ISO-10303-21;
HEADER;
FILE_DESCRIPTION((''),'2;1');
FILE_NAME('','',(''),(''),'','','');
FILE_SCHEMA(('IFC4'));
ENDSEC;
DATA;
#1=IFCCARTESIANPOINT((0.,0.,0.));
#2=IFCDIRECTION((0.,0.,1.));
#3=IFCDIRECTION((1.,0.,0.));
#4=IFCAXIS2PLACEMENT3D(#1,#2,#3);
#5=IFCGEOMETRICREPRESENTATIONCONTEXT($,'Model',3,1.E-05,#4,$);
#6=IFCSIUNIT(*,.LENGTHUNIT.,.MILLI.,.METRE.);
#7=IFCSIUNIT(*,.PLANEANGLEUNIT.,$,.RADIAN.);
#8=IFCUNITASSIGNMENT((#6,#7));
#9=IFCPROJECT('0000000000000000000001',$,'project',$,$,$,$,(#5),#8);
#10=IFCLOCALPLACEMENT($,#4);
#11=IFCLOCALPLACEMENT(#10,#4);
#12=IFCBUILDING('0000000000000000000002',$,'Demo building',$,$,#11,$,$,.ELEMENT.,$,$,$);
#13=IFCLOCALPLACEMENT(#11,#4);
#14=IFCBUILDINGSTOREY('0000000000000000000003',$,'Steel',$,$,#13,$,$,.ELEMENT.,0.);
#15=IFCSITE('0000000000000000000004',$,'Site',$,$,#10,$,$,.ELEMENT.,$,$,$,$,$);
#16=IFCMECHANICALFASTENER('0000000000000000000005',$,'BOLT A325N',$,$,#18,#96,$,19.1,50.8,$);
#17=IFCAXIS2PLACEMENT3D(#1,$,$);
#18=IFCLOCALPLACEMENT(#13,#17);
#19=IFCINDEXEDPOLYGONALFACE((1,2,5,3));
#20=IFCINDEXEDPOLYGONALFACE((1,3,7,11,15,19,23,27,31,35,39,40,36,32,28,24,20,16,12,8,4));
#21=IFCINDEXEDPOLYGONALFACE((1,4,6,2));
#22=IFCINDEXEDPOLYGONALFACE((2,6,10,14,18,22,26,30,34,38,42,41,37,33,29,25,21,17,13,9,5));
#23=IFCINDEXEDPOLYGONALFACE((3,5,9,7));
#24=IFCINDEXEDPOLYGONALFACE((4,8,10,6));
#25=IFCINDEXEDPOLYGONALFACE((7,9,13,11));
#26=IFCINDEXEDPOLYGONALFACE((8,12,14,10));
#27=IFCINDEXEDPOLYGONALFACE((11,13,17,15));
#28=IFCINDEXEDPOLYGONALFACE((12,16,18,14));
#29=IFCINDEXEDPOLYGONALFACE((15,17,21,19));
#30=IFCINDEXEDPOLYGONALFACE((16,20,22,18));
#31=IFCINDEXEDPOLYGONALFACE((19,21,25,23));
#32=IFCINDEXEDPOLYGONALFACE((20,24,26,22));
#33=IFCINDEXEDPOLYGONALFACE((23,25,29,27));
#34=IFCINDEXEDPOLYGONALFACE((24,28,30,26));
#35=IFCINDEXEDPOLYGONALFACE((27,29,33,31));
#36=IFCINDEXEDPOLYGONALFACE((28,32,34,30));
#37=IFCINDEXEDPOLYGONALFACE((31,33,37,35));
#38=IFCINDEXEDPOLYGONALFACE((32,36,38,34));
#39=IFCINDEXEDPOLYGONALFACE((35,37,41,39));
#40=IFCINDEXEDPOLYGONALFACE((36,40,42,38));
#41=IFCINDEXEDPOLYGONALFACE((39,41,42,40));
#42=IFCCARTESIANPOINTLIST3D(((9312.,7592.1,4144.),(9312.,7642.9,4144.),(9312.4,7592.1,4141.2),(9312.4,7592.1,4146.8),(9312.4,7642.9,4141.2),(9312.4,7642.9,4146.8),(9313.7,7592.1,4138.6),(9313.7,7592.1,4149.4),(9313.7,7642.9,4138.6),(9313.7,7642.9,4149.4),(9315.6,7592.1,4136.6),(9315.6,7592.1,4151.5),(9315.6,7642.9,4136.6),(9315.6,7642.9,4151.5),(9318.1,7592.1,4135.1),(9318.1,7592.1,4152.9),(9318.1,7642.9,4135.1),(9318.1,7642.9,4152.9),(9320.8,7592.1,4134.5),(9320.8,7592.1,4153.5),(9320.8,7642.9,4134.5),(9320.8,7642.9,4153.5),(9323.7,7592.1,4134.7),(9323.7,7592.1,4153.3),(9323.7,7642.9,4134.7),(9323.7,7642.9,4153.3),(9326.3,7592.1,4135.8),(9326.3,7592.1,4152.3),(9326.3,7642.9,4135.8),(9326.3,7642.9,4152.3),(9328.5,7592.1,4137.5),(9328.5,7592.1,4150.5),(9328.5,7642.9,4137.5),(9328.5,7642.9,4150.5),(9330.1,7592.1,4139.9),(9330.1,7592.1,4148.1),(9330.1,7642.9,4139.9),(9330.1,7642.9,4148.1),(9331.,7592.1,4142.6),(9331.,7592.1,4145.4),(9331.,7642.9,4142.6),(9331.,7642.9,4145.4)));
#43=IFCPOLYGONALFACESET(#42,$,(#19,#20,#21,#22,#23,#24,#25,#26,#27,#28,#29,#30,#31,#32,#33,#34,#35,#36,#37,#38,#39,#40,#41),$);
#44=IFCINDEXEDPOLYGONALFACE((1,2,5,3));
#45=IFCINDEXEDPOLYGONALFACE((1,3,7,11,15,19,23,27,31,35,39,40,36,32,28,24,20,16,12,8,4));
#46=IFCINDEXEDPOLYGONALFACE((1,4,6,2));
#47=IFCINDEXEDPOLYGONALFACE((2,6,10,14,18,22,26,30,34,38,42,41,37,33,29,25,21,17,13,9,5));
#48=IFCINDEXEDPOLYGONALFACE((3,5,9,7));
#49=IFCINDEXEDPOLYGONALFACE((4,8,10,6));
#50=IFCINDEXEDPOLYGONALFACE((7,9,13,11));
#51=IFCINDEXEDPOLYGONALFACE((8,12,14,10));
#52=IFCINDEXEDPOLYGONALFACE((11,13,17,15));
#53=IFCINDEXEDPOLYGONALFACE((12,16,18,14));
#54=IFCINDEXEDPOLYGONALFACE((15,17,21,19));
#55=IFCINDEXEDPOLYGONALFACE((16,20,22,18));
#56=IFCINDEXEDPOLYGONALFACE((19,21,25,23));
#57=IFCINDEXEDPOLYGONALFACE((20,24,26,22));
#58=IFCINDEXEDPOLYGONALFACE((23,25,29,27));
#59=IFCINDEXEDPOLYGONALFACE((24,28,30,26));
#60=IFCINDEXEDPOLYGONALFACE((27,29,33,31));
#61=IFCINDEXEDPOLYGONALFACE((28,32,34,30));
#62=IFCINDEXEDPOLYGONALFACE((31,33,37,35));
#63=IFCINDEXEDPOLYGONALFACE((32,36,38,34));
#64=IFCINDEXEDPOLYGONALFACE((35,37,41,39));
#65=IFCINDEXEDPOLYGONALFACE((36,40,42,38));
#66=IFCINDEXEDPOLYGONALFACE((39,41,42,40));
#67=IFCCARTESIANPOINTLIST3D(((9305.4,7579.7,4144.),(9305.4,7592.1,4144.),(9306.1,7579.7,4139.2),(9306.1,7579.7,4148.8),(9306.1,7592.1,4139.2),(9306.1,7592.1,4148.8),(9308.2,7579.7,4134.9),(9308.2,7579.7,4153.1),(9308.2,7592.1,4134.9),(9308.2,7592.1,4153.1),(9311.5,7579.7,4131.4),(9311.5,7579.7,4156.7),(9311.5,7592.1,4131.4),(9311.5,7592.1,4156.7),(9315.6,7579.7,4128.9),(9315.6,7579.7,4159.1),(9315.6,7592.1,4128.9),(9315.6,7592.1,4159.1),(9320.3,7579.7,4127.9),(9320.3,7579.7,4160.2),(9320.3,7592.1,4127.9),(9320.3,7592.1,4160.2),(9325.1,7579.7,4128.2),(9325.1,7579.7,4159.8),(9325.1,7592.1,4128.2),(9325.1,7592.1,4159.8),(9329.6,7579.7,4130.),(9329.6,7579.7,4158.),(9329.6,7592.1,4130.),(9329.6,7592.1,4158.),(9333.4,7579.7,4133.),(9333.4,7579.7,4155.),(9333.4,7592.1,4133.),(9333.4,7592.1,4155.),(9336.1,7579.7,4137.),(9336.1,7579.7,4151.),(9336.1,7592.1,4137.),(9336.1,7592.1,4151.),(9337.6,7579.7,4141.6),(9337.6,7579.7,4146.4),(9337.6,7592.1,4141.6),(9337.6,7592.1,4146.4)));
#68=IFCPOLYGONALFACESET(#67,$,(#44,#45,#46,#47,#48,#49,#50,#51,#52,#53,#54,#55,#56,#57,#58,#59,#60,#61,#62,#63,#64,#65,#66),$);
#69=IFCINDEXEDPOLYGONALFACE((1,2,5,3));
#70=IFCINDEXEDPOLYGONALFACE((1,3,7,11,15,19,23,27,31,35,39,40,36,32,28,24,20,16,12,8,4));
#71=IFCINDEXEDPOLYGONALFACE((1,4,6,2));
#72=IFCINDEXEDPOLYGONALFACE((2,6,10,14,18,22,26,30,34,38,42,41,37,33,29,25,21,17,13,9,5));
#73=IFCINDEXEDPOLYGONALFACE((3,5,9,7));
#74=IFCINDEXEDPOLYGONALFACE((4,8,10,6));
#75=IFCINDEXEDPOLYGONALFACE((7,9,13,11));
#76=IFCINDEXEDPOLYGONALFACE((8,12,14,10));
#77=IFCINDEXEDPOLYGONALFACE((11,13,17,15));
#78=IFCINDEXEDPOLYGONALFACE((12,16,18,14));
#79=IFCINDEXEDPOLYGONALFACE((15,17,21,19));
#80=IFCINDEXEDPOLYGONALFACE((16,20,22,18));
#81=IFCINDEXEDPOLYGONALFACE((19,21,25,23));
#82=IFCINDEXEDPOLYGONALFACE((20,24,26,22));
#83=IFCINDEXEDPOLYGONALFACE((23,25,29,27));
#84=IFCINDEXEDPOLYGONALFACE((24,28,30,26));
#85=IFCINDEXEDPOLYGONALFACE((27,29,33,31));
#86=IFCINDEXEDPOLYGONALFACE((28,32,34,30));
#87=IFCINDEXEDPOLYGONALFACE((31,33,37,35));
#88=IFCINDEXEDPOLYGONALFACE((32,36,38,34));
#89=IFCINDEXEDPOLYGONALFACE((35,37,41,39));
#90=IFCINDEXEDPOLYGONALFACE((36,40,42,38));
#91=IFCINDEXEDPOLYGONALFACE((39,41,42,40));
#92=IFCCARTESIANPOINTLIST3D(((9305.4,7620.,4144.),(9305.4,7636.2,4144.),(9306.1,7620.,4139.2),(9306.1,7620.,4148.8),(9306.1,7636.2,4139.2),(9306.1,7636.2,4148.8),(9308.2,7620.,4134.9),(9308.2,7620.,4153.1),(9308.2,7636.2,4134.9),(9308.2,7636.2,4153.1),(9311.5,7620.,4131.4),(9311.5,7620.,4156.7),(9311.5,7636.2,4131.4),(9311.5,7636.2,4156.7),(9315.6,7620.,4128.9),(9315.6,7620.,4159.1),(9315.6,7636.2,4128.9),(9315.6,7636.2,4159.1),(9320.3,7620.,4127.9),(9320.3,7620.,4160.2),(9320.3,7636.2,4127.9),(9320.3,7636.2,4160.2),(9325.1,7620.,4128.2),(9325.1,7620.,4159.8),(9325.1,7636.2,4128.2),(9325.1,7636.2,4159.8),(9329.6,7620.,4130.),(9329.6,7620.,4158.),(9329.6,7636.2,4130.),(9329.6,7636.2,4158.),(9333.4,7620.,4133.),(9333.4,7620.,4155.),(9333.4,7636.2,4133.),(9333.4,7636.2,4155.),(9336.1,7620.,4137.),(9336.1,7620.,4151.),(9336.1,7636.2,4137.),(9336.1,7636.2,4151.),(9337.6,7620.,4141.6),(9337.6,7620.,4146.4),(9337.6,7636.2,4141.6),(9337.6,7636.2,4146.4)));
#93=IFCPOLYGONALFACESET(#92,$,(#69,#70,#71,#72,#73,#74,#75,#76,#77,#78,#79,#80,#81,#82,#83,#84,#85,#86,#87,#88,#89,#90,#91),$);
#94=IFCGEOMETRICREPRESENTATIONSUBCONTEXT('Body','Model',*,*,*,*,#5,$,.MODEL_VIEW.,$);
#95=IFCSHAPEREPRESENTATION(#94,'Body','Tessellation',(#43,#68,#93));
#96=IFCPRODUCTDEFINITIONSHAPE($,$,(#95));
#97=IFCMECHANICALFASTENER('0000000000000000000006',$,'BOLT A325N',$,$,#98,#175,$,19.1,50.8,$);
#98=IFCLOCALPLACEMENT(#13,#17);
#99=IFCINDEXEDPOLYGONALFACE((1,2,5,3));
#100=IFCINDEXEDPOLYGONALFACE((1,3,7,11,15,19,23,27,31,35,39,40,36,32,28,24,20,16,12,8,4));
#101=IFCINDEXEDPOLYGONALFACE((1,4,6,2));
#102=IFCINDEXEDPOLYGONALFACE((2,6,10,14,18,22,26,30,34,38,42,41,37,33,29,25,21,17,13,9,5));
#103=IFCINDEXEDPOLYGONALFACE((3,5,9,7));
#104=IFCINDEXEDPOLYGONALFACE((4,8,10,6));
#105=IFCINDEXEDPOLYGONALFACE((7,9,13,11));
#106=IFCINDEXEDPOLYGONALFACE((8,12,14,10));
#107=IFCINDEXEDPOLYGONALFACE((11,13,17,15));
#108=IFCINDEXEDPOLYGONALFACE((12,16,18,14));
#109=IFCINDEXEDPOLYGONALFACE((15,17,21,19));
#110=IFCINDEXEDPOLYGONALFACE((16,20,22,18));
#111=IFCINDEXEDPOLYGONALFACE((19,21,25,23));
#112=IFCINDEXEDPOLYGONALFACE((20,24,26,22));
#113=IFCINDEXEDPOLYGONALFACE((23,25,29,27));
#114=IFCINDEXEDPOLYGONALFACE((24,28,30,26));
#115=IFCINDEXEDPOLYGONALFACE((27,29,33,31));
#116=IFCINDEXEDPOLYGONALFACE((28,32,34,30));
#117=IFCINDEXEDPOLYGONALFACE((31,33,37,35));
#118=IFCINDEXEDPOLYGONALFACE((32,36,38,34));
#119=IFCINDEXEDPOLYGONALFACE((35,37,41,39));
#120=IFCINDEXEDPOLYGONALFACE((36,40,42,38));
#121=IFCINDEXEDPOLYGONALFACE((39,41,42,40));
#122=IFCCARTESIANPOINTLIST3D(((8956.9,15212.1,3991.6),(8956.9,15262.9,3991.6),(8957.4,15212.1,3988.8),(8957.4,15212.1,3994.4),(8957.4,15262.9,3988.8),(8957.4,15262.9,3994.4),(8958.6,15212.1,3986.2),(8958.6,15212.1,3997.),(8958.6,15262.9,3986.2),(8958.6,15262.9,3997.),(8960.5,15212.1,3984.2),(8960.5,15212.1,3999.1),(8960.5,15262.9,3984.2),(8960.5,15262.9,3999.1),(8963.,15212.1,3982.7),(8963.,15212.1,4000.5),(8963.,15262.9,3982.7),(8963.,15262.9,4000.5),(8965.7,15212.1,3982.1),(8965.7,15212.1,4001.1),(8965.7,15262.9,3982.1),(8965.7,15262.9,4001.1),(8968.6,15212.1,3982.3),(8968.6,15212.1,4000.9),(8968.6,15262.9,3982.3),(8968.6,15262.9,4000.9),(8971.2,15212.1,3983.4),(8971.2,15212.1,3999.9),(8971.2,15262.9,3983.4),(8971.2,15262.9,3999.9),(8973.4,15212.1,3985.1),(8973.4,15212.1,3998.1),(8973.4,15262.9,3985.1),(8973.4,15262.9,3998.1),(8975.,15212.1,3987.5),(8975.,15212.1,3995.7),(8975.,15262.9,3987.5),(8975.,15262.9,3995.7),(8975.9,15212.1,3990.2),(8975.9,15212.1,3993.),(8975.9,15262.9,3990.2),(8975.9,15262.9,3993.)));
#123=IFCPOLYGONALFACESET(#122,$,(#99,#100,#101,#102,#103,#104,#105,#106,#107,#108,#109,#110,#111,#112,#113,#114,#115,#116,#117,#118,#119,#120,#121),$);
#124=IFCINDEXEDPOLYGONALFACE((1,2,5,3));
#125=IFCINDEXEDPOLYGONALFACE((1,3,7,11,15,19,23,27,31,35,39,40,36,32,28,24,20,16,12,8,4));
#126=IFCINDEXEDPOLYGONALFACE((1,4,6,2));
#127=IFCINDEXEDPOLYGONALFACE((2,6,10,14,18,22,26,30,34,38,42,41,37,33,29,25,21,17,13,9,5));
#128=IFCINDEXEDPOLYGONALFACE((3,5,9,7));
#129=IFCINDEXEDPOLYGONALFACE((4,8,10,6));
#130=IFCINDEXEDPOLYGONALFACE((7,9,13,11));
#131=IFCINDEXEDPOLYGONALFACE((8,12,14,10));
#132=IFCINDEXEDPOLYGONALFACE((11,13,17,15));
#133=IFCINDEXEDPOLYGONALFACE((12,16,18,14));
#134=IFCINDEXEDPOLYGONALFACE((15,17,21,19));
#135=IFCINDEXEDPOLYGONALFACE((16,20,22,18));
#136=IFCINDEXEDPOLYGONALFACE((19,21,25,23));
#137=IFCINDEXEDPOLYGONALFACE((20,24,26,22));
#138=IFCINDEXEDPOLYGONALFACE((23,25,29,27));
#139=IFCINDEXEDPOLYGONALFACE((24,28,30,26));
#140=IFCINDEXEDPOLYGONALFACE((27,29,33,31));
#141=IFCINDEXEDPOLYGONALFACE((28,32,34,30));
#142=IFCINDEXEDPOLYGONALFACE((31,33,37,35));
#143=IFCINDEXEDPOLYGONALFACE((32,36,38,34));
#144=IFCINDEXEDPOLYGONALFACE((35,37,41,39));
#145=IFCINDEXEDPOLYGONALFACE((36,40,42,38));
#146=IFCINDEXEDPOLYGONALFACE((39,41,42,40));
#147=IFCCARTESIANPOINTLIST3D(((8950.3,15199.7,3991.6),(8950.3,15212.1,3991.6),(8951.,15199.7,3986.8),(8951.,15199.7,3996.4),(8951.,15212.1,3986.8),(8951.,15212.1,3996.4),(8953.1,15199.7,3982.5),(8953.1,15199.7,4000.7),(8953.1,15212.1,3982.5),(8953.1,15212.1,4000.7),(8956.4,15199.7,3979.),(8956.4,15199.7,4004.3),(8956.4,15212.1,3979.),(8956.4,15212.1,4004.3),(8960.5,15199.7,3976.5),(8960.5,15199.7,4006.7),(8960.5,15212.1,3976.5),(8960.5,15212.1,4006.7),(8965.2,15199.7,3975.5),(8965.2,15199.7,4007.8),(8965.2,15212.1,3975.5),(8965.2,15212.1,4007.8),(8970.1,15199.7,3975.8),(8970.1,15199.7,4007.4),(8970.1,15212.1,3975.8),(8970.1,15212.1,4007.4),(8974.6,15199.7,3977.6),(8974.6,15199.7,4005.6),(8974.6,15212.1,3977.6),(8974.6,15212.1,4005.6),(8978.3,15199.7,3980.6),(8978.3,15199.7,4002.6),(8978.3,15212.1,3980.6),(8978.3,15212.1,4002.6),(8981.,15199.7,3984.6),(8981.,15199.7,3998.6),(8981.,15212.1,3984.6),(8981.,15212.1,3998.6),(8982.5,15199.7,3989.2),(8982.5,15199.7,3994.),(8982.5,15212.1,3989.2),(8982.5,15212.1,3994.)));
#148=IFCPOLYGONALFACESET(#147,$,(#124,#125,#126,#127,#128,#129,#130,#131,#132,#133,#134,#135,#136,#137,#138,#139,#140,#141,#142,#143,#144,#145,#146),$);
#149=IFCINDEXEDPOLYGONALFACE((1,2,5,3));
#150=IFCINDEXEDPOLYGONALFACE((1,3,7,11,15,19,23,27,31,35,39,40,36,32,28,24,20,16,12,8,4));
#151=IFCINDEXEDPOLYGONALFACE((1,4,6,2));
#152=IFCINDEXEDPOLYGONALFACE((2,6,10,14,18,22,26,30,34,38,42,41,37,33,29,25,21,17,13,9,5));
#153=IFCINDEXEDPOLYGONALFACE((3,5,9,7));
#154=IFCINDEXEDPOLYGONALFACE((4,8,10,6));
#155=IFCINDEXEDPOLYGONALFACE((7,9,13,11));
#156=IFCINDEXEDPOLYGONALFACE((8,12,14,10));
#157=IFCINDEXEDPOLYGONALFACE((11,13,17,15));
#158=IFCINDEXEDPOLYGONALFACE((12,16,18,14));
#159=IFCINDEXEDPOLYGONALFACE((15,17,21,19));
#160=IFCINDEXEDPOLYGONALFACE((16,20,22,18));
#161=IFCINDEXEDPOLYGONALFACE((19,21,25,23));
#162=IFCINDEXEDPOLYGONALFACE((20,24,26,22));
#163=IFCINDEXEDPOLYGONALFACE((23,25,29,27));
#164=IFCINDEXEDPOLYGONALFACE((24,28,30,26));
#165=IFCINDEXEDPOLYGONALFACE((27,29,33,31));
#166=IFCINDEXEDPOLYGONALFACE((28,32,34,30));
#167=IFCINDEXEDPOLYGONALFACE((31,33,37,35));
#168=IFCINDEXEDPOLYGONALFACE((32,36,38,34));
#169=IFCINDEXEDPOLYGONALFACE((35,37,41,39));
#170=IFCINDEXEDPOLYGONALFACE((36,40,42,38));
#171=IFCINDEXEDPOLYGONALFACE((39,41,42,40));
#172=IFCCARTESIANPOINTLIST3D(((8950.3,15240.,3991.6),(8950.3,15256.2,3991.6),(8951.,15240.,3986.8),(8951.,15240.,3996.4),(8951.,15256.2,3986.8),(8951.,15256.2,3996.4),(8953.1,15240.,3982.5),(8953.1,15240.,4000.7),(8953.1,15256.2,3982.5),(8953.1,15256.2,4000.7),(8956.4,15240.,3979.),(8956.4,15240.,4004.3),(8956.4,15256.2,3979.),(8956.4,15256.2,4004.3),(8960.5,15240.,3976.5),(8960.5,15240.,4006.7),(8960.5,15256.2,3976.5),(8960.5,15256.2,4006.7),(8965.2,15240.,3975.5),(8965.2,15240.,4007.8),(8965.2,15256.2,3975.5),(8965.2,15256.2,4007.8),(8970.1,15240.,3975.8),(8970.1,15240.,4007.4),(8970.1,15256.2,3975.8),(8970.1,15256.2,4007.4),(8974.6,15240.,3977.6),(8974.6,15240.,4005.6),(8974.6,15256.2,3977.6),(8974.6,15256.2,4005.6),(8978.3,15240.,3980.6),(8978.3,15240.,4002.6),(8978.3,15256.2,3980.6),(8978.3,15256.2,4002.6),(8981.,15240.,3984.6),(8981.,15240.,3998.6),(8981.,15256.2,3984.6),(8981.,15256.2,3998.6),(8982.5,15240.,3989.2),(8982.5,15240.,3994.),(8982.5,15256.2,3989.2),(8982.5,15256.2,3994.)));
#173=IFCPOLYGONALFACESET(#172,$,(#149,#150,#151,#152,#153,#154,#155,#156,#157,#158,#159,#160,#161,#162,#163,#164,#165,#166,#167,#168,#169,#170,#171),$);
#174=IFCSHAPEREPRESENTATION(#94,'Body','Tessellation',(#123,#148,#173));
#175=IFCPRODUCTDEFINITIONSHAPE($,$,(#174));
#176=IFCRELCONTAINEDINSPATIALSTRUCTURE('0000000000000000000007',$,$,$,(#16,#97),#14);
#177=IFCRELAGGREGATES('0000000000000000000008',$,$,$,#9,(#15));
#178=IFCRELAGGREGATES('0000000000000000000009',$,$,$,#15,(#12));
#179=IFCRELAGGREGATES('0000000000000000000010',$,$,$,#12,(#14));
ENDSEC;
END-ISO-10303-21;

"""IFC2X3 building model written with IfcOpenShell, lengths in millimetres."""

from ifc_helpers import new_model, si_unit, frame, origin, origin_with_axes, origin_2d, place, context, subcontext, project, spatial, circle, extrude, element, save


model = new_model("IFC2X3")

# Units and contexts
model_context = context("Model", 3, precision=1e-05, world=origin_with_axes())
body_context = subcontext(model_context, "Body", "Model", "MODEL_VIEW")
ifc_project = project(units=[si_unit("LENGTHUNIT", "METRE", prefix="MILLI"), si_unit("PLANEANGLEUNIT", "RADIAN")], contexts=[model_context])

# Site, building, storey
site_placement = place(None, origin_with_axes())
site = spatial("IfcSite", under=ifc_project, at=site_placement, Name="Site", CompositionType="ELEMENT")
building_placement = place(site_placement, origin_with_axes())
building = spatial("IfcBuilding", under=site, at=building_placement, Name="Demo building", CompositionType="ELEMENT")
placement = place(building_placement, origin_with_axes())
storey = spatial("IfcBuildingStorey", under=building, at=placement, Name="Steel", CompositionType="ELEMENT", Elevation=0.0)

# Mechanical fasteners
for number, where, z_axis, x_axis, name in (
    (1, (9321.5, 7592.1, 4144.0), (0.0, 1.0, 0.0), (-1.0, 0.0, 0.0), "BOLT A325N"),
    (2, (8966.5, 15212.1, 3991.6), (0.0, 1.0, 0.0), (-1.0, 0.0, 0.0), "BOLT A325N"),
):
    element("IfcMechanicalFastener", number, at=place(placement, frame(where, z_axis=z_axis, x_axis=x_axis)), inside=storey, Name=name, NominalDiameter=19.1, NominalLength=50.8, context=body_context, shape_type="SweptSolid", body=[
        extrude(circle(Radius=9.5, at=origin_2d()), origin(), (0.0, 0.0, 1.0), 50.8),
        extrude(circle(Radius=16.2, at=origin_2d()), frame((0.0, 0.0, -12.4)), (0.0, 0.0, 1.0), 12.4),
        extrude(circle(Radius=16.2, at=origin_2d()), frame((0.0, 0.0, 27.9)), (0.0, 0.0, 1.0), 16.2),
    ])

save(model, "model.ifc")
